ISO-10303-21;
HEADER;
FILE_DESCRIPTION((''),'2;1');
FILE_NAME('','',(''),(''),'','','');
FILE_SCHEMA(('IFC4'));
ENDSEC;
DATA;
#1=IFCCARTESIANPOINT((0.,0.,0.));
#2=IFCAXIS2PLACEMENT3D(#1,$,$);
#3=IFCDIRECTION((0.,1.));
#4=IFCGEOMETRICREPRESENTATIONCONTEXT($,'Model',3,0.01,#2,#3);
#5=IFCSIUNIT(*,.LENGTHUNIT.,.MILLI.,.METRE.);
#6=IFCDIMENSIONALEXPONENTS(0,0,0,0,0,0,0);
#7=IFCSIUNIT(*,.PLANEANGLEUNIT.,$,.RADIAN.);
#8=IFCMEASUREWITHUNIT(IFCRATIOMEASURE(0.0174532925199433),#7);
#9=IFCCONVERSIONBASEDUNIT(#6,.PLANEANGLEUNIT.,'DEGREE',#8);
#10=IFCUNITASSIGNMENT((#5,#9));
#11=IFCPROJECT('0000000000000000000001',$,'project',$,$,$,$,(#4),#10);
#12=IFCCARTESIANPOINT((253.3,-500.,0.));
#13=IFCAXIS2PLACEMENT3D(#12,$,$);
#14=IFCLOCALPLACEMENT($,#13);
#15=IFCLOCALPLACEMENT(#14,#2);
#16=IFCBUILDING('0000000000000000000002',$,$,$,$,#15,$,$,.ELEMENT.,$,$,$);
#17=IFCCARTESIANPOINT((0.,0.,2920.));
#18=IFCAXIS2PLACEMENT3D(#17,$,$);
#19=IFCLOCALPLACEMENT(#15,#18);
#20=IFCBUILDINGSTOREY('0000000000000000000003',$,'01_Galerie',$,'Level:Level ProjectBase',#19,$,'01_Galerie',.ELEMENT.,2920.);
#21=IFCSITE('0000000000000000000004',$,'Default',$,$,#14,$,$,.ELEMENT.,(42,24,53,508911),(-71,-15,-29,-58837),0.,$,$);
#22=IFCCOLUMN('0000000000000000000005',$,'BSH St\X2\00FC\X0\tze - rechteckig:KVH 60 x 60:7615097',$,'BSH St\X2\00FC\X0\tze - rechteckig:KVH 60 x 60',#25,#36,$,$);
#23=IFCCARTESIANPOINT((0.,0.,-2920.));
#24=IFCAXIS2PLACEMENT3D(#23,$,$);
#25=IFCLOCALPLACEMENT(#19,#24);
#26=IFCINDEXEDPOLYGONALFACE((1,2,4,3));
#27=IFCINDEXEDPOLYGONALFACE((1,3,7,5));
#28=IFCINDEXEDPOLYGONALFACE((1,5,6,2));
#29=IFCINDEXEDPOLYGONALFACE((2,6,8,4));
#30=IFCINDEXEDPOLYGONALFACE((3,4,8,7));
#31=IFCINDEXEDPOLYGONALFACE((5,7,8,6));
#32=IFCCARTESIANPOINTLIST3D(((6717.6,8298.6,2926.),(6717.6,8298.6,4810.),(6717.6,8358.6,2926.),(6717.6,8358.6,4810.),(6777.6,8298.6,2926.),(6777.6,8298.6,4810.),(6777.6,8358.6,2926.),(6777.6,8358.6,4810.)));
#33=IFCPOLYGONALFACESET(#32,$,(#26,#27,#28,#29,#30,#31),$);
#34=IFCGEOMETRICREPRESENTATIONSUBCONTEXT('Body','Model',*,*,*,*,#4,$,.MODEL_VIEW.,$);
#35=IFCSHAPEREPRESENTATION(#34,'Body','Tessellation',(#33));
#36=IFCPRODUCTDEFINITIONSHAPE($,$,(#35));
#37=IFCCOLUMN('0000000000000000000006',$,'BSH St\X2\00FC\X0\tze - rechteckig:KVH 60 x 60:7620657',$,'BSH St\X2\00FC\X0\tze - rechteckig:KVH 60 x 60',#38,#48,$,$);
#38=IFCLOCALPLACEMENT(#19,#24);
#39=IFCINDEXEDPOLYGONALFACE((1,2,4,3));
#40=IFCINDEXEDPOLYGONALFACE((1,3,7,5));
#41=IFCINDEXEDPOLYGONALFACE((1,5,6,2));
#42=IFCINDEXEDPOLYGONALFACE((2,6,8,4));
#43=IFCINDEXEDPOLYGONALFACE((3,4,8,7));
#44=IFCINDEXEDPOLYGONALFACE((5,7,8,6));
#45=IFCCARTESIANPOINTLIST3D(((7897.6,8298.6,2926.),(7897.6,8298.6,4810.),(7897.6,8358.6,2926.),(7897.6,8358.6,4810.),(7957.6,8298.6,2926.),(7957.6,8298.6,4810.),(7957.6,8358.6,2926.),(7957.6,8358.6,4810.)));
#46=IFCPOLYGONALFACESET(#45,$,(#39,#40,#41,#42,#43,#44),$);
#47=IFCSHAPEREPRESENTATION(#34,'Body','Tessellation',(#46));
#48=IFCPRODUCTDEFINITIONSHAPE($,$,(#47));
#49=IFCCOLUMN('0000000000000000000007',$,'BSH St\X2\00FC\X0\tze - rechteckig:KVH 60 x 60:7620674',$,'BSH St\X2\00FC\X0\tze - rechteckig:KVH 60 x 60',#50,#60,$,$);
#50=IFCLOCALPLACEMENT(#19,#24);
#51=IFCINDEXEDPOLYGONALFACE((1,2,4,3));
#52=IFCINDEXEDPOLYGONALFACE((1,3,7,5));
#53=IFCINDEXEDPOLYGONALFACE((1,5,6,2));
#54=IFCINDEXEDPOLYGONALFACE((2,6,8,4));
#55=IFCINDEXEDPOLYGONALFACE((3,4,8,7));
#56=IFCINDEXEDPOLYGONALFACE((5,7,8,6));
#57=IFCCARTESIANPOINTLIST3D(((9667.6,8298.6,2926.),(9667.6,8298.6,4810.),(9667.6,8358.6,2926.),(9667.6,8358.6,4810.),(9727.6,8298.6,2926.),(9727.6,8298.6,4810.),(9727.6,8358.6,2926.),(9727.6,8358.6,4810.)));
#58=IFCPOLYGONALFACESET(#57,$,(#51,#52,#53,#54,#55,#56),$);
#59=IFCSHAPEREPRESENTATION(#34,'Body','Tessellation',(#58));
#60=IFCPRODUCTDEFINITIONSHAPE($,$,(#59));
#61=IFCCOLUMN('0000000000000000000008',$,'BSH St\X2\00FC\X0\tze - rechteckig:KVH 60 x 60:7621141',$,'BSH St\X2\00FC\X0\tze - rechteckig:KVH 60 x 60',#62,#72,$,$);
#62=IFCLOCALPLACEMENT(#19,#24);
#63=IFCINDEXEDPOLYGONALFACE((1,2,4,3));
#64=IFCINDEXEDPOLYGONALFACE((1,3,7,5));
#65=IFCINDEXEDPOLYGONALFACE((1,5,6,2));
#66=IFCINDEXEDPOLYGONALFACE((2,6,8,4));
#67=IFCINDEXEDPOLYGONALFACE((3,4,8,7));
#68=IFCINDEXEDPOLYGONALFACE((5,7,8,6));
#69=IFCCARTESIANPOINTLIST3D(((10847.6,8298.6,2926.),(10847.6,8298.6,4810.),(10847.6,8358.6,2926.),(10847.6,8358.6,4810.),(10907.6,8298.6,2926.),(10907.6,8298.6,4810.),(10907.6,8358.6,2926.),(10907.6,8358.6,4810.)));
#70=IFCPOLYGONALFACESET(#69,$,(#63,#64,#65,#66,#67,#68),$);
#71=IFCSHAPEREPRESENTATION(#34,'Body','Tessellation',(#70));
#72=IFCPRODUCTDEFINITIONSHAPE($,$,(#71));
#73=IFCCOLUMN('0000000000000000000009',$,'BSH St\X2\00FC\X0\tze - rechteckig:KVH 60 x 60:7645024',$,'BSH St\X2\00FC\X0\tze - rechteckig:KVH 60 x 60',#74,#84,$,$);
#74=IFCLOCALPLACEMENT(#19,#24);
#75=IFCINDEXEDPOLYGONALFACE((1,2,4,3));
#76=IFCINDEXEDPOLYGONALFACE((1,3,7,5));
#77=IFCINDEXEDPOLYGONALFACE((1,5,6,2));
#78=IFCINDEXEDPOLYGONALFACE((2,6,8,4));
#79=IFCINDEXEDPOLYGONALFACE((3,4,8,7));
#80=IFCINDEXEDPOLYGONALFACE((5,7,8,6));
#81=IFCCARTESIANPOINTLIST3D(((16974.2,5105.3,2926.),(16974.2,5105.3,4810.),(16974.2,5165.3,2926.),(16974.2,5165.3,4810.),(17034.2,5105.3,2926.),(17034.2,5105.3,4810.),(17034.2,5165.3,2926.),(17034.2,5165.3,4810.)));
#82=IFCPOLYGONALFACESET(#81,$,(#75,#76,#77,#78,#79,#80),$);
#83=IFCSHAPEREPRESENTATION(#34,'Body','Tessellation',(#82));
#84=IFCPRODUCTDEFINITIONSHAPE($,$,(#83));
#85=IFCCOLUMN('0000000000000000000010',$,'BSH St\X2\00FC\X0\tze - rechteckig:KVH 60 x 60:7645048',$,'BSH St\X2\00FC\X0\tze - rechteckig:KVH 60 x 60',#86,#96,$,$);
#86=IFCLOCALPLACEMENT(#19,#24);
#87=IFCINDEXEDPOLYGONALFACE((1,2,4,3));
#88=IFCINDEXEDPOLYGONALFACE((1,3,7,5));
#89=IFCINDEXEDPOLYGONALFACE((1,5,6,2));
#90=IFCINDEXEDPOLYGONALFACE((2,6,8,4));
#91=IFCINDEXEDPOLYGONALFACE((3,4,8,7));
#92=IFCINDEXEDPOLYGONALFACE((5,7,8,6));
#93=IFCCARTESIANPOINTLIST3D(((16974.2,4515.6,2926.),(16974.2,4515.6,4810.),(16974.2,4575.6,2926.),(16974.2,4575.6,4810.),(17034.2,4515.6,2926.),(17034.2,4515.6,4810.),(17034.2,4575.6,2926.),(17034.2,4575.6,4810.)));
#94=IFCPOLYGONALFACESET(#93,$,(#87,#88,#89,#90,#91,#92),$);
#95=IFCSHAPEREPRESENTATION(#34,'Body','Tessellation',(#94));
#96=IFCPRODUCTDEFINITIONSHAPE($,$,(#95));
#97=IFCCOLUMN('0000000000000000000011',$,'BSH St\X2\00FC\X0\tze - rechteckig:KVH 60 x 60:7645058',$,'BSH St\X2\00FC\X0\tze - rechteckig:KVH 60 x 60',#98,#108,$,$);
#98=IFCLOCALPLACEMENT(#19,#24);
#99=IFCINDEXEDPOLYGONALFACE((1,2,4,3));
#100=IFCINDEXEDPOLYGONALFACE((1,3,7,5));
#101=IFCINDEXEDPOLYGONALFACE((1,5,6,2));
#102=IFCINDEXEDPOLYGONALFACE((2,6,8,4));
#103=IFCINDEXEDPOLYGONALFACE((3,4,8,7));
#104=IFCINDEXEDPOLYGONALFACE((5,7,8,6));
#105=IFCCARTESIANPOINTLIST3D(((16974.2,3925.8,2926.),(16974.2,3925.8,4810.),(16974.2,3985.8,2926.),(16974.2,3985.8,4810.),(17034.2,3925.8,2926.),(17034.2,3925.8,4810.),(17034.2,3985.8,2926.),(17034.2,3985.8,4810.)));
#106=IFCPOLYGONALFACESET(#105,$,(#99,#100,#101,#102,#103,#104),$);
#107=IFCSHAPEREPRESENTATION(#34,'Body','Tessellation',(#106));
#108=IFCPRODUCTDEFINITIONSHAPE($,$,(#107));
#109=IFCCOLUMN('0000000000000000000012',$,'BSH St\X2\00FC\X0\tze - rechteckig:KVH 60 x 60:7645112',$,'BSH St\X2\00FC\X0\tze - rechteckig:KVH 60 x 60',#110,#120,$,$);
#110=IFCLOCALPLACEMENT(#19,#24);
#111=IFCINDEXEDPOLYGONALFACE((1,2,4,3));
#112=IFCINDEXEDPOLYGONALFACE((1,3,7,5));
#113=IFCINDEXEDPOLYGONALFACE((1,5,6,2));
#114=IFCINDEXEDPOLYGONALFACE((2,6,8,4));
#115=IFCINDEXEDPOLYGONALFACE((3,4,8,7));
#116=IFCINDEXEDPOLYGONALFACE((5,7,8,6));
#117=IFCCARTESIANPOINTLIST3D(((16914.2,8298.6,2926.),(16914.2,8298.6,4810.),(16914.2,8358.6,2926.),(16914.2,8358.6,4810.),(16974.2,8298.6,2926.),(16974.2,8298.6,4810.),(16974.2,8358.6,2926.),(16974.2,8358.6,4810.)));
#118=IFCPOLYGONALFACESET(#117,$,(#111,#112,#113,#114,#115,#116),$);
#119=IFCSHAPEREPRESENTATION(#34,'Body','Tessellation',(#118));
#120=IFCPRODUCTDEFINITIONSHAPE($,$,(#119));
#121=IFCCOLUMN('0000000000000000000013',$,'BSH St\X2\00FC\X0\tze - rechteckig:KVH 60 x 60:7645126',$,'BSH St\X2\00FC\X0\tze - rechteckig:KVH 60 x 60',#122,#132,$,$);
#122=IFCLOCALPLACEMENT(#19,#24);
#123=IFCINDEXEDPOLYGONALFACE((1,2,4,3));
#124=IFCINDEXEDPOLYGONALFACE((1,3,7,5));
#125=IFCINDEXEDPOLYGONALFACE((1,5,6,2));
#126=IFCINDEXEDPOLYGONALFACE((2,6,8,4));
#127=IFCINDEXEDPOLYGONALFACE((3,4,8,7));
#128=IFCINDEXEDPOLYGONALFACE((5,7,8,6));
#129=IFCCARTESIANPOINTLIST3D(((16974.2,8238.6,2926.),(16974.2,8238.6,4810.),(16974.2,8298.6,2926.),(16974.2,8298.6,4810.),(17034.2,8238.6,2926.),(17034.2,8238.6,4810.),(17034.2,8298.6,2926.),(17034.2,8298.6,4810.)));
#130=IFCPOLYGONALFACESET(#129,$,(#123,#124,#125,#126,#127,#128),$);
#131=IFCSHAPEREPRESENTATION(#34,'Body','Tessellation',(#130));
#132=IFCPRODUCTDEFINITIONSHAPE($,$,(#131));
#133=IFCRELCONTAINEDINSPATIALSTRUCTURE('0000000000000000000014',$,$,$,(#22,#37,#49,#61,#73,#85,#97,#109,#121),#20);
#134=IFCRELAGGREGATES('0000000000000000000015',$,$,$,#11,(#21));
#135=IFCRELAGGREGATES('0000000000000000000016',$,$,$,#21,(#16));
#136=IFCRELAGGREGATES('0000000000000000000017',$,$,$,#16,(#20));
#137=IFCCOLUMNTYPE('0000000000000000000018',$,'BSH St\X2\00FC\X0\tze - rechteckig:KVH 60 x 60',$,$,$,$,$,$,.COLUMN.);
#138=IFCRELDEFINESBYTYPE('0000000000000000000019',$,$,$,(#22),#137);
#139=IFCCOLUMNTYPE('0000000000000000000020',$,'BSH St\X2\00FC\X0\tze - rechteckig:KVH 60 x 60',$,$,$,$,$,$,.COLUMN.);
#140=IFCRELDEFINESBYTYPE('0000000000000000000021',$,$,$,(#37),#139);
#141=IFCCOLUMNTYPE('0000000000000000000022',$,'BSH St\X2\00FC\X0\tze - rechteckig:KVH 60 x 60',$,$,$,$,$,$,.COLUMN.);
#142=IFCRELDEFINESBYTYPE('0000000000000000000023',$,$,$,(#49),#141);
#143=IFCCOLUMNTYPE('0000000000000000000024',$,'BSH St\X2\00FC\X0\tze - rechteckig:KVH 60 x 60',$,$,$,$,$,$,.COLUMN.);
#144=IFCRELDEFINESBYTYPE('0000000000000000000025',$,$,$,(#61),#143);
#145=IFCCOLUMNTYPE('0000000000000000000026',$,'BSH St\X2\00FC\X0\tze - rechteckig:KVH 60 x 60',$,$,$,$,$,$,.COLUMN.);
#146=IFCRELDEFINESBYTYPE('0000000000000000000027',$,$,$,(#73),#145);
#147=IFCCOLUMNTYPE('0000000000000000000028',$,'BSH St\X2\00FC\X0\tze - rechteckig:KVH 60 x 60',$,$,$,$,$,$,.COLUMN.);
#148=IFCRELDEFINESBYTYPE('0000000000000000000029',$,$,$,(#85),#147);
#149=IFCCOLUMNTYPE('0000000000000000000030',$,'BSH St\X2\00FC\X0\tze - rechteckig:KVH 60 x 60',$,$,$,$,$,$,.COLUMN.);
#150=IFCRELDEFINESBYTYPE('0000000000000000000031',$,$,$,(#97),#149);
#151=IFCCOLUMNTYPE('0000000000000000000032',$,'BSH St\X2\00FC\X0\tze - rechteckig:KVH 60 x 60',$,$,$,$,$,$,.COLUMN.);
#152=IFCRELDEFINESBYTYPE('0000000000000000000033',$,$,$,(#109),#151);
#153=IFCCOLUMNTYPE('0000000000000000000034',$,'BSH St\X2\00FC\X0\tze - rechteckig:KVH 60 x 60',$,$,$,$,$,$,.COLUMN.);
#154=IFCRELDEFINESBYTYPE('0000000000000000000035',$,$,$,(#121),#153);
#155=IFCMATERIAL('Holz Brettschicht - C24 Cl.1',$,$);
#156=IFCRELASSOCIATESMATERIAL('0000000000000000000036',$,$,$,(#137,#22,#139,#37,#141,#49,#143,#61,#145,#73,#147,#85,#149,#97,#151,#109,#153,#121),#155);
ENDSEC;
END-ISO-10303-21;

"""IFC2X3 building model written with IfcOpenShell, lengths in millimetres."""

from ifc_helpers import new_model, entity, si_unit, converted_unit, direction, frame, frame_2d, origin, origin_2d_with_axis, place, context, subcontext, project, spatial, rectangle, extrude, source, transform, mapped, material, type_object, type_shapes, element, save


model = new_model("IFC2X3")

# Units and contexts
model_context = context("Model", 3, precision=0.01, world=origin(), true_north=direction((0.0, 1.0)))
body_context = subcontext(model_context, "Body", "Model", "MODEL_VIEW")
ifc_project = project(units=[si_unit("LENGTHUNIT", "METRE", prefix="MILLI"), converted_unit("PLANEANGLEUNIT", "DEGREE", entity("IfcRatioMeasure", 0.0174532925199433), si_unit("PLANEANGLEUNIT", "RADIAN"), dimensions=[0, 0, 0, 0, 0, 0, 0])], contexts=[model_context])

# Site, building, storey
site_placement = place(None, frame((253.3, -500.0, 0.0)))
site = spatial("IfcSite", under=ifc_project, at=site_placement, Name="Default", CompositionType="ELEMENT", RefLatitude=(42, 24, 53, 508911), RefLongitude=(-71, -15, -29, -58837), RefElevation=0.0)
building_placement = place(site_placement, origin())
building = spatial("IfcBuilding", under=site, at=building_placement, CompositionType="ELEMENT")
storey_placement = place(building_placement, frame((0.0, 0.0, 2920.0)))
storey = spatial("IfcBuildingStorey", under=building, at=storey_placement, Name="01_Galerie", ObjectType="Level:Level ProjectBase", LongName="01_Galerie", CompositionType="ELEMENT", Elevation=2920.0)

# Columns
ifc_material_1 = material(Name="Holz Brettschicht - C24 Cl.1")
column_type_1 = type_object("IfcColumnType", Name="BSH Stütze - rechteckig:KVH 60 x 60", PredefinedType="COLUMN", material=ifc_material_1)
shared_shape_1 = source(origin(), body_context, "Body", "SweptSolid", [
    extrude(rectangle(XDim=60.0, YDim=60.0, at=origin_2d_with_axis()), frame((6747.6, 8328.6, 2926.0), z_axis=(0.0, 0.0, 1.0), x_axis=(0.0, -1.0, 0.0)), (0.0, 0.0, 1.0), 1884.0),
])
type_shapes(column_type_1, [shared_shape_1])
column_1_placement = place(storey_placement, frame((0.0, 0.0, -2920.0)))
element("IfcColumn", 1, at=column_1_placement, inside=storey, type_object=column_type_1, material=ifc_material_1, Name="BSH Stütze - rechteckig:KVH 60 x 60:7615097", ObjectType="BSH Stütze - rechteckig:KVH 60 x 60", context=body_context, shape_type="MappedRepresentation", body=[
    mapped(shared_shape_1, transform((0.0, 0.0, 0.0), scale=1.0)),
])
column_type_2 = type_object("IfcColumnType", Name="BSH Stütze - rechteckig:KVH 60 x 60", PredefinedType="COLUMN", material=ifc_material_1)
shared_shape_2 = source(origin(), body_context, "Body", "SweptSolid", [
    extrude(rectangle(XDim=60.0, YDim=60.0, at=origin_2d_with_axis()), frame((7927.6, 8328.6, 2926.0), z_axis=(0.0, 0.0, 1.0), x_axis=(0.0, -1.0, 0.0)), (0.0, 0.0, 1.0), 1884.0),
])
type_shapes(column_type_2, [shared_shape_2])
column_2_placement = place(storey_placement, frame((0.0, 0.0, -2920.0)))
element("IfcColumn", 2, at=column_2_placement, inside=storey, type_object=column_type_2, material=ifc_material_1, Name="BSH Stütze - rechteckig:KVH 60 x 60:7620657", ObjectType="BSH Stütze - rechteckig:KVH 60 x 60", context=body_context, shape_type="MappedRepresentation", body=[
    mapped(shared_shape_2, transform((0.0, 0.0, 0.0), scale=1.0)),
])
column_type_3 = type_object("IfcColumnType", Name="BSH Stütze - rechteckig:KVH 60 x 60", PredefinedType="COLUMN", material=ifc_material_1)
shared_shape_3 = source(origin(), body_context, "Body", "SweptSolid", [
    extrude(rectangle(XDim=60.0, YDim=60.0, at=origin_2d_with_axis()), frame((9697.6, 8328.6, 2926.0), z_axis=(0.0, 0.0, 1.0), x_axis=(0.0, -1.0, 0.0)), (0.0, 0.0, 1.0), 1884.0),
])
type_shapes(column_type_3, [shared_shape_3])
column_3_placement = place(storey_placement, frame((0.0, 0.0, -2920.0)))
element("IfcColumn", 3, at=column_3_placement, inside=storey, type_object=column_type_3, material=ifc_material_1, Name="BSH Stütze - rechteckig:KVH 60 x 60:7620674", ObjectType="BSH Stütze - rechteckig:KVH 60 x 60", context=body_context, shape_type="MappedRepresentation", body=[
    mapped(shared_shape_3, transform((0.0, 0.0, 0.0), scale=1.0)),
])
column_type_4 = type_object("IfcColumnType", Name="BSH Stütze - rechteckig:KVH 60 x 60", PredefinedType="COLUMN", material=ifc_material_1)
shared_shape_4 = source(origin(), body_context, "Body", "SweptSolid", [
    extrude(rectangle(XDim=60.0, YDim=60.0, at=origin_2d_with_axis()), frame((10877.6, 8328.6, 2926.0), z_axis=(0.0, 0.0, 1.0), x_axis=(0.0, -1.0, 0.0)), (0.0, 0.0, 1.0), 1884.0),
])
type_shapes(column_type_4, [shared_shape_4])
column_4_placement = place(storey_placement, frame((0.0, 0.0, -2920.0)))
element("IfcColumn", 4, at=column_4_placement, inside=storey, type_object=column_type_4, material=ifc_material_1, Name="BSH Stütze - rechteckig:KVH 60 x 60:7621141", ObjectType="BSH Stütze - rechteckig:KVH 60 x 60", context=body_context, shape_type="MappedRepresentation", body=[
    mapped(shared_shape_4, transform((0.0, 0.0, 0.0), scale=1.0)),
])
column_type_5 = type_object("IfcColumnType", Name="BSH Stütze - rechteckig:KVH 60 x 60", PredefinedType="COLUMN", material=ifc_material_1)
shared_shape_5 = source(origin(), body_context, "Body", "SweptSolid", [
    extrude(rectangle(XDim=60.0, YDim=60.0, at=origin_2d_with_axis()), frame((17004.2, 5135.3, 2926.0), z_axis=(0.0, 0.0, 1.0), x_axis=(0.0, -1.0, 0.0)), (0.0, 0.0, 1.0), 1884.0),
])
type_shapes(column_type_5, [shared_shape_5])
column_5_placement = place(storey_placement, frame((0.0, 0.0, -2920.0)))
element("IfcColumn", 5, at=column_5_placement, inside=storey, type_object=column_type_5, material=ifc_material_1, Name="BSH Stütze - rechteckig:KVH 60 x 60:7645024", ObjectType="BSH Stütze - rechteckig:KVH 60 x 60", context=body_context, shape_type="MappedRepresentation", body=[
    mapped(shared_shape_5, transform((0.0, 0.0, 0.0), scale=1.0)),
])
column_type_6 = type_object("IfcColumnType", Name="BSH Stütze - rechteckig:KVH 60 x 60", PredefinedType="COLUMN", material=ifc_material_1)
shared_shape_6 = source(origin(), body_context, "Body", "SweptSolid", [
    extrude(rectangle(XDim=60.0, YDim=60.0, at=frame_2d((0.0, 0.0), x_axis=(1.0, 0.0))), frame((17004.2, 4545.6, 2926.0), z_axis=(0.0, 0.0, 1.0), x_axis=(0.0, -1.0, 0.0)), (0.0, 0.0, 1.0), 1884.0),
])
type_shapes(column_type_6, [shared_shape_6])
column_6_placement = place(storey_placement, frame((0.0, 0.0, -2920.0)))
element("IfcColumn", 6, at=column_6_placement, inside=storey, type_object=column_type_6, material=ifc_material_1, Name="BSH Stütze - rechteckig:KVH 60 x 60:7645048", ObjectType="BSH Stütze - rechteckig:KVH 60 x 60", context=body_context, shape_type="MappedRepresentation", body=[
    mapped(shared_shape_6, transform((0.0, 0.0, 0.0), scale=1.0)),
])
column_type_7 = type_object("IfcColumnType", Name="BSH Stütze - rechteckig:KVH 60 x 60", PredefinedType="COLUMN", material=ifc_material_1)
shared_shape_7 = source(origin(), body_context, "Body", "SweptSolid", [
    extrude(rectangle(XDim=60.0, YDim=60.0, at=frame_2d((0.0, 0.0), x_axis=(1.0, 0.0))), frame((17004.2, 3955.8, 2926.0), z_axis=(0.0, 0.0, 1.0), x_axis=(0.0, -1.0, 0.0)), (0.0, 0.0, 1.0), 1884.0),
])
type_shapes(column_type_7, [shared_shape_7])
column_7_placement = place(storey_placement, frame((0.0, 0.0, -2920.0)))
element("IfcColumn", 7, at=column_7_placement, inside=storey, type_object=column_type_7, material=ifc_material_1, Name="BSH Stütze - rechteckig:KVH 60 x 60:7645058", ObjectType="BSH Stütze - rechteckig:KVH 60 x 60", context=body_context, shape_type="MappedRepresentation", body=[
    mapped(shared_shape_7, transform((0.0, 0.0, 0.0), scale=1.0)),
])
column_type_8 = type_object("IfcColumnType", Name="BSH Stütze - rechteckig:KVH 60 x 60", PredefinedType="COLUMN", material=ifc_material_1)
shared_shape_8 = source(origin(), body_context, "Body", "SweptSolid", [
    extrude(rectangle(XDim=60.0, YDim=60.0, at=origin_2d_with_axis()), frame((16944.2, 8328.6, 2926.0), z_axis=(0.0, 0.0, 1.0), x_axis=(0.0, -1.0, 0.0)), (0.0, 0.0, 1.0), 1884.0),
])
type_shapes(column_type_8, [shared_shape_8])
column_8_placement = place(storey_placement, frame((0.0, 0.0, -2920.0)))
element("IfcColumn", 8, at=column_8_placement, inside=storey, type_object=column_type_8, material=ifc_material_1, Name="BSH Stütze - rechteckig:KVH 60 x 60:7645112", ObjectType="BSH Stütze - rechteckig:KVH 60 x 60", context=body_context, shape_type="MappedRepresentation", body=[
    mapped(shared_shape_8, transform((0.0, 0.0, 0.0), scale=1.0)),
])
column_type_9 = type_object("IfcColumnType", Name="BSH Stütze - rechteckig:KVH 60 x 60", PredefinedType="COLUMN", material=ifc_material_1)
shared_shape_9 = source(origin(), body_context, "Body", "SweptSolid", [
    extrude(rectangle(XDim=60.0, YDim=60.0, at=frame_2d((0.0, 0.0), x_axis=(1.0, 0.0))), frame((17004.2, 8268.6, 2926.0), z_axis=(0.0, 0.0, 1.0), x_axis=(0.0, -1.0, 0.0)), (0.0, 0.0, 1.0), 1884.0),
])
type_shapes(column_type_9, [shared_shape_9])
column_9_placement = place(storey_placement, frame((0.0, 0.0, -2920.0)))
element("IfcColumn", 9, at=column_9_placement, inside=storey, type_object=column_type_9, material=ifc_material_1, Name="BSH Stütze - rechteckig:KVH 60 x 60:7645126", ObjectType="BSH Stütze - rechteckig:KVH 60 x 60", context=body_context, shape_type="MappedRepresentation", body=[
    mapped(shared_shape_9, transform((0.0, 0.0, 0.0), scale=1.0)),
])

save(model, "model.ifc")
